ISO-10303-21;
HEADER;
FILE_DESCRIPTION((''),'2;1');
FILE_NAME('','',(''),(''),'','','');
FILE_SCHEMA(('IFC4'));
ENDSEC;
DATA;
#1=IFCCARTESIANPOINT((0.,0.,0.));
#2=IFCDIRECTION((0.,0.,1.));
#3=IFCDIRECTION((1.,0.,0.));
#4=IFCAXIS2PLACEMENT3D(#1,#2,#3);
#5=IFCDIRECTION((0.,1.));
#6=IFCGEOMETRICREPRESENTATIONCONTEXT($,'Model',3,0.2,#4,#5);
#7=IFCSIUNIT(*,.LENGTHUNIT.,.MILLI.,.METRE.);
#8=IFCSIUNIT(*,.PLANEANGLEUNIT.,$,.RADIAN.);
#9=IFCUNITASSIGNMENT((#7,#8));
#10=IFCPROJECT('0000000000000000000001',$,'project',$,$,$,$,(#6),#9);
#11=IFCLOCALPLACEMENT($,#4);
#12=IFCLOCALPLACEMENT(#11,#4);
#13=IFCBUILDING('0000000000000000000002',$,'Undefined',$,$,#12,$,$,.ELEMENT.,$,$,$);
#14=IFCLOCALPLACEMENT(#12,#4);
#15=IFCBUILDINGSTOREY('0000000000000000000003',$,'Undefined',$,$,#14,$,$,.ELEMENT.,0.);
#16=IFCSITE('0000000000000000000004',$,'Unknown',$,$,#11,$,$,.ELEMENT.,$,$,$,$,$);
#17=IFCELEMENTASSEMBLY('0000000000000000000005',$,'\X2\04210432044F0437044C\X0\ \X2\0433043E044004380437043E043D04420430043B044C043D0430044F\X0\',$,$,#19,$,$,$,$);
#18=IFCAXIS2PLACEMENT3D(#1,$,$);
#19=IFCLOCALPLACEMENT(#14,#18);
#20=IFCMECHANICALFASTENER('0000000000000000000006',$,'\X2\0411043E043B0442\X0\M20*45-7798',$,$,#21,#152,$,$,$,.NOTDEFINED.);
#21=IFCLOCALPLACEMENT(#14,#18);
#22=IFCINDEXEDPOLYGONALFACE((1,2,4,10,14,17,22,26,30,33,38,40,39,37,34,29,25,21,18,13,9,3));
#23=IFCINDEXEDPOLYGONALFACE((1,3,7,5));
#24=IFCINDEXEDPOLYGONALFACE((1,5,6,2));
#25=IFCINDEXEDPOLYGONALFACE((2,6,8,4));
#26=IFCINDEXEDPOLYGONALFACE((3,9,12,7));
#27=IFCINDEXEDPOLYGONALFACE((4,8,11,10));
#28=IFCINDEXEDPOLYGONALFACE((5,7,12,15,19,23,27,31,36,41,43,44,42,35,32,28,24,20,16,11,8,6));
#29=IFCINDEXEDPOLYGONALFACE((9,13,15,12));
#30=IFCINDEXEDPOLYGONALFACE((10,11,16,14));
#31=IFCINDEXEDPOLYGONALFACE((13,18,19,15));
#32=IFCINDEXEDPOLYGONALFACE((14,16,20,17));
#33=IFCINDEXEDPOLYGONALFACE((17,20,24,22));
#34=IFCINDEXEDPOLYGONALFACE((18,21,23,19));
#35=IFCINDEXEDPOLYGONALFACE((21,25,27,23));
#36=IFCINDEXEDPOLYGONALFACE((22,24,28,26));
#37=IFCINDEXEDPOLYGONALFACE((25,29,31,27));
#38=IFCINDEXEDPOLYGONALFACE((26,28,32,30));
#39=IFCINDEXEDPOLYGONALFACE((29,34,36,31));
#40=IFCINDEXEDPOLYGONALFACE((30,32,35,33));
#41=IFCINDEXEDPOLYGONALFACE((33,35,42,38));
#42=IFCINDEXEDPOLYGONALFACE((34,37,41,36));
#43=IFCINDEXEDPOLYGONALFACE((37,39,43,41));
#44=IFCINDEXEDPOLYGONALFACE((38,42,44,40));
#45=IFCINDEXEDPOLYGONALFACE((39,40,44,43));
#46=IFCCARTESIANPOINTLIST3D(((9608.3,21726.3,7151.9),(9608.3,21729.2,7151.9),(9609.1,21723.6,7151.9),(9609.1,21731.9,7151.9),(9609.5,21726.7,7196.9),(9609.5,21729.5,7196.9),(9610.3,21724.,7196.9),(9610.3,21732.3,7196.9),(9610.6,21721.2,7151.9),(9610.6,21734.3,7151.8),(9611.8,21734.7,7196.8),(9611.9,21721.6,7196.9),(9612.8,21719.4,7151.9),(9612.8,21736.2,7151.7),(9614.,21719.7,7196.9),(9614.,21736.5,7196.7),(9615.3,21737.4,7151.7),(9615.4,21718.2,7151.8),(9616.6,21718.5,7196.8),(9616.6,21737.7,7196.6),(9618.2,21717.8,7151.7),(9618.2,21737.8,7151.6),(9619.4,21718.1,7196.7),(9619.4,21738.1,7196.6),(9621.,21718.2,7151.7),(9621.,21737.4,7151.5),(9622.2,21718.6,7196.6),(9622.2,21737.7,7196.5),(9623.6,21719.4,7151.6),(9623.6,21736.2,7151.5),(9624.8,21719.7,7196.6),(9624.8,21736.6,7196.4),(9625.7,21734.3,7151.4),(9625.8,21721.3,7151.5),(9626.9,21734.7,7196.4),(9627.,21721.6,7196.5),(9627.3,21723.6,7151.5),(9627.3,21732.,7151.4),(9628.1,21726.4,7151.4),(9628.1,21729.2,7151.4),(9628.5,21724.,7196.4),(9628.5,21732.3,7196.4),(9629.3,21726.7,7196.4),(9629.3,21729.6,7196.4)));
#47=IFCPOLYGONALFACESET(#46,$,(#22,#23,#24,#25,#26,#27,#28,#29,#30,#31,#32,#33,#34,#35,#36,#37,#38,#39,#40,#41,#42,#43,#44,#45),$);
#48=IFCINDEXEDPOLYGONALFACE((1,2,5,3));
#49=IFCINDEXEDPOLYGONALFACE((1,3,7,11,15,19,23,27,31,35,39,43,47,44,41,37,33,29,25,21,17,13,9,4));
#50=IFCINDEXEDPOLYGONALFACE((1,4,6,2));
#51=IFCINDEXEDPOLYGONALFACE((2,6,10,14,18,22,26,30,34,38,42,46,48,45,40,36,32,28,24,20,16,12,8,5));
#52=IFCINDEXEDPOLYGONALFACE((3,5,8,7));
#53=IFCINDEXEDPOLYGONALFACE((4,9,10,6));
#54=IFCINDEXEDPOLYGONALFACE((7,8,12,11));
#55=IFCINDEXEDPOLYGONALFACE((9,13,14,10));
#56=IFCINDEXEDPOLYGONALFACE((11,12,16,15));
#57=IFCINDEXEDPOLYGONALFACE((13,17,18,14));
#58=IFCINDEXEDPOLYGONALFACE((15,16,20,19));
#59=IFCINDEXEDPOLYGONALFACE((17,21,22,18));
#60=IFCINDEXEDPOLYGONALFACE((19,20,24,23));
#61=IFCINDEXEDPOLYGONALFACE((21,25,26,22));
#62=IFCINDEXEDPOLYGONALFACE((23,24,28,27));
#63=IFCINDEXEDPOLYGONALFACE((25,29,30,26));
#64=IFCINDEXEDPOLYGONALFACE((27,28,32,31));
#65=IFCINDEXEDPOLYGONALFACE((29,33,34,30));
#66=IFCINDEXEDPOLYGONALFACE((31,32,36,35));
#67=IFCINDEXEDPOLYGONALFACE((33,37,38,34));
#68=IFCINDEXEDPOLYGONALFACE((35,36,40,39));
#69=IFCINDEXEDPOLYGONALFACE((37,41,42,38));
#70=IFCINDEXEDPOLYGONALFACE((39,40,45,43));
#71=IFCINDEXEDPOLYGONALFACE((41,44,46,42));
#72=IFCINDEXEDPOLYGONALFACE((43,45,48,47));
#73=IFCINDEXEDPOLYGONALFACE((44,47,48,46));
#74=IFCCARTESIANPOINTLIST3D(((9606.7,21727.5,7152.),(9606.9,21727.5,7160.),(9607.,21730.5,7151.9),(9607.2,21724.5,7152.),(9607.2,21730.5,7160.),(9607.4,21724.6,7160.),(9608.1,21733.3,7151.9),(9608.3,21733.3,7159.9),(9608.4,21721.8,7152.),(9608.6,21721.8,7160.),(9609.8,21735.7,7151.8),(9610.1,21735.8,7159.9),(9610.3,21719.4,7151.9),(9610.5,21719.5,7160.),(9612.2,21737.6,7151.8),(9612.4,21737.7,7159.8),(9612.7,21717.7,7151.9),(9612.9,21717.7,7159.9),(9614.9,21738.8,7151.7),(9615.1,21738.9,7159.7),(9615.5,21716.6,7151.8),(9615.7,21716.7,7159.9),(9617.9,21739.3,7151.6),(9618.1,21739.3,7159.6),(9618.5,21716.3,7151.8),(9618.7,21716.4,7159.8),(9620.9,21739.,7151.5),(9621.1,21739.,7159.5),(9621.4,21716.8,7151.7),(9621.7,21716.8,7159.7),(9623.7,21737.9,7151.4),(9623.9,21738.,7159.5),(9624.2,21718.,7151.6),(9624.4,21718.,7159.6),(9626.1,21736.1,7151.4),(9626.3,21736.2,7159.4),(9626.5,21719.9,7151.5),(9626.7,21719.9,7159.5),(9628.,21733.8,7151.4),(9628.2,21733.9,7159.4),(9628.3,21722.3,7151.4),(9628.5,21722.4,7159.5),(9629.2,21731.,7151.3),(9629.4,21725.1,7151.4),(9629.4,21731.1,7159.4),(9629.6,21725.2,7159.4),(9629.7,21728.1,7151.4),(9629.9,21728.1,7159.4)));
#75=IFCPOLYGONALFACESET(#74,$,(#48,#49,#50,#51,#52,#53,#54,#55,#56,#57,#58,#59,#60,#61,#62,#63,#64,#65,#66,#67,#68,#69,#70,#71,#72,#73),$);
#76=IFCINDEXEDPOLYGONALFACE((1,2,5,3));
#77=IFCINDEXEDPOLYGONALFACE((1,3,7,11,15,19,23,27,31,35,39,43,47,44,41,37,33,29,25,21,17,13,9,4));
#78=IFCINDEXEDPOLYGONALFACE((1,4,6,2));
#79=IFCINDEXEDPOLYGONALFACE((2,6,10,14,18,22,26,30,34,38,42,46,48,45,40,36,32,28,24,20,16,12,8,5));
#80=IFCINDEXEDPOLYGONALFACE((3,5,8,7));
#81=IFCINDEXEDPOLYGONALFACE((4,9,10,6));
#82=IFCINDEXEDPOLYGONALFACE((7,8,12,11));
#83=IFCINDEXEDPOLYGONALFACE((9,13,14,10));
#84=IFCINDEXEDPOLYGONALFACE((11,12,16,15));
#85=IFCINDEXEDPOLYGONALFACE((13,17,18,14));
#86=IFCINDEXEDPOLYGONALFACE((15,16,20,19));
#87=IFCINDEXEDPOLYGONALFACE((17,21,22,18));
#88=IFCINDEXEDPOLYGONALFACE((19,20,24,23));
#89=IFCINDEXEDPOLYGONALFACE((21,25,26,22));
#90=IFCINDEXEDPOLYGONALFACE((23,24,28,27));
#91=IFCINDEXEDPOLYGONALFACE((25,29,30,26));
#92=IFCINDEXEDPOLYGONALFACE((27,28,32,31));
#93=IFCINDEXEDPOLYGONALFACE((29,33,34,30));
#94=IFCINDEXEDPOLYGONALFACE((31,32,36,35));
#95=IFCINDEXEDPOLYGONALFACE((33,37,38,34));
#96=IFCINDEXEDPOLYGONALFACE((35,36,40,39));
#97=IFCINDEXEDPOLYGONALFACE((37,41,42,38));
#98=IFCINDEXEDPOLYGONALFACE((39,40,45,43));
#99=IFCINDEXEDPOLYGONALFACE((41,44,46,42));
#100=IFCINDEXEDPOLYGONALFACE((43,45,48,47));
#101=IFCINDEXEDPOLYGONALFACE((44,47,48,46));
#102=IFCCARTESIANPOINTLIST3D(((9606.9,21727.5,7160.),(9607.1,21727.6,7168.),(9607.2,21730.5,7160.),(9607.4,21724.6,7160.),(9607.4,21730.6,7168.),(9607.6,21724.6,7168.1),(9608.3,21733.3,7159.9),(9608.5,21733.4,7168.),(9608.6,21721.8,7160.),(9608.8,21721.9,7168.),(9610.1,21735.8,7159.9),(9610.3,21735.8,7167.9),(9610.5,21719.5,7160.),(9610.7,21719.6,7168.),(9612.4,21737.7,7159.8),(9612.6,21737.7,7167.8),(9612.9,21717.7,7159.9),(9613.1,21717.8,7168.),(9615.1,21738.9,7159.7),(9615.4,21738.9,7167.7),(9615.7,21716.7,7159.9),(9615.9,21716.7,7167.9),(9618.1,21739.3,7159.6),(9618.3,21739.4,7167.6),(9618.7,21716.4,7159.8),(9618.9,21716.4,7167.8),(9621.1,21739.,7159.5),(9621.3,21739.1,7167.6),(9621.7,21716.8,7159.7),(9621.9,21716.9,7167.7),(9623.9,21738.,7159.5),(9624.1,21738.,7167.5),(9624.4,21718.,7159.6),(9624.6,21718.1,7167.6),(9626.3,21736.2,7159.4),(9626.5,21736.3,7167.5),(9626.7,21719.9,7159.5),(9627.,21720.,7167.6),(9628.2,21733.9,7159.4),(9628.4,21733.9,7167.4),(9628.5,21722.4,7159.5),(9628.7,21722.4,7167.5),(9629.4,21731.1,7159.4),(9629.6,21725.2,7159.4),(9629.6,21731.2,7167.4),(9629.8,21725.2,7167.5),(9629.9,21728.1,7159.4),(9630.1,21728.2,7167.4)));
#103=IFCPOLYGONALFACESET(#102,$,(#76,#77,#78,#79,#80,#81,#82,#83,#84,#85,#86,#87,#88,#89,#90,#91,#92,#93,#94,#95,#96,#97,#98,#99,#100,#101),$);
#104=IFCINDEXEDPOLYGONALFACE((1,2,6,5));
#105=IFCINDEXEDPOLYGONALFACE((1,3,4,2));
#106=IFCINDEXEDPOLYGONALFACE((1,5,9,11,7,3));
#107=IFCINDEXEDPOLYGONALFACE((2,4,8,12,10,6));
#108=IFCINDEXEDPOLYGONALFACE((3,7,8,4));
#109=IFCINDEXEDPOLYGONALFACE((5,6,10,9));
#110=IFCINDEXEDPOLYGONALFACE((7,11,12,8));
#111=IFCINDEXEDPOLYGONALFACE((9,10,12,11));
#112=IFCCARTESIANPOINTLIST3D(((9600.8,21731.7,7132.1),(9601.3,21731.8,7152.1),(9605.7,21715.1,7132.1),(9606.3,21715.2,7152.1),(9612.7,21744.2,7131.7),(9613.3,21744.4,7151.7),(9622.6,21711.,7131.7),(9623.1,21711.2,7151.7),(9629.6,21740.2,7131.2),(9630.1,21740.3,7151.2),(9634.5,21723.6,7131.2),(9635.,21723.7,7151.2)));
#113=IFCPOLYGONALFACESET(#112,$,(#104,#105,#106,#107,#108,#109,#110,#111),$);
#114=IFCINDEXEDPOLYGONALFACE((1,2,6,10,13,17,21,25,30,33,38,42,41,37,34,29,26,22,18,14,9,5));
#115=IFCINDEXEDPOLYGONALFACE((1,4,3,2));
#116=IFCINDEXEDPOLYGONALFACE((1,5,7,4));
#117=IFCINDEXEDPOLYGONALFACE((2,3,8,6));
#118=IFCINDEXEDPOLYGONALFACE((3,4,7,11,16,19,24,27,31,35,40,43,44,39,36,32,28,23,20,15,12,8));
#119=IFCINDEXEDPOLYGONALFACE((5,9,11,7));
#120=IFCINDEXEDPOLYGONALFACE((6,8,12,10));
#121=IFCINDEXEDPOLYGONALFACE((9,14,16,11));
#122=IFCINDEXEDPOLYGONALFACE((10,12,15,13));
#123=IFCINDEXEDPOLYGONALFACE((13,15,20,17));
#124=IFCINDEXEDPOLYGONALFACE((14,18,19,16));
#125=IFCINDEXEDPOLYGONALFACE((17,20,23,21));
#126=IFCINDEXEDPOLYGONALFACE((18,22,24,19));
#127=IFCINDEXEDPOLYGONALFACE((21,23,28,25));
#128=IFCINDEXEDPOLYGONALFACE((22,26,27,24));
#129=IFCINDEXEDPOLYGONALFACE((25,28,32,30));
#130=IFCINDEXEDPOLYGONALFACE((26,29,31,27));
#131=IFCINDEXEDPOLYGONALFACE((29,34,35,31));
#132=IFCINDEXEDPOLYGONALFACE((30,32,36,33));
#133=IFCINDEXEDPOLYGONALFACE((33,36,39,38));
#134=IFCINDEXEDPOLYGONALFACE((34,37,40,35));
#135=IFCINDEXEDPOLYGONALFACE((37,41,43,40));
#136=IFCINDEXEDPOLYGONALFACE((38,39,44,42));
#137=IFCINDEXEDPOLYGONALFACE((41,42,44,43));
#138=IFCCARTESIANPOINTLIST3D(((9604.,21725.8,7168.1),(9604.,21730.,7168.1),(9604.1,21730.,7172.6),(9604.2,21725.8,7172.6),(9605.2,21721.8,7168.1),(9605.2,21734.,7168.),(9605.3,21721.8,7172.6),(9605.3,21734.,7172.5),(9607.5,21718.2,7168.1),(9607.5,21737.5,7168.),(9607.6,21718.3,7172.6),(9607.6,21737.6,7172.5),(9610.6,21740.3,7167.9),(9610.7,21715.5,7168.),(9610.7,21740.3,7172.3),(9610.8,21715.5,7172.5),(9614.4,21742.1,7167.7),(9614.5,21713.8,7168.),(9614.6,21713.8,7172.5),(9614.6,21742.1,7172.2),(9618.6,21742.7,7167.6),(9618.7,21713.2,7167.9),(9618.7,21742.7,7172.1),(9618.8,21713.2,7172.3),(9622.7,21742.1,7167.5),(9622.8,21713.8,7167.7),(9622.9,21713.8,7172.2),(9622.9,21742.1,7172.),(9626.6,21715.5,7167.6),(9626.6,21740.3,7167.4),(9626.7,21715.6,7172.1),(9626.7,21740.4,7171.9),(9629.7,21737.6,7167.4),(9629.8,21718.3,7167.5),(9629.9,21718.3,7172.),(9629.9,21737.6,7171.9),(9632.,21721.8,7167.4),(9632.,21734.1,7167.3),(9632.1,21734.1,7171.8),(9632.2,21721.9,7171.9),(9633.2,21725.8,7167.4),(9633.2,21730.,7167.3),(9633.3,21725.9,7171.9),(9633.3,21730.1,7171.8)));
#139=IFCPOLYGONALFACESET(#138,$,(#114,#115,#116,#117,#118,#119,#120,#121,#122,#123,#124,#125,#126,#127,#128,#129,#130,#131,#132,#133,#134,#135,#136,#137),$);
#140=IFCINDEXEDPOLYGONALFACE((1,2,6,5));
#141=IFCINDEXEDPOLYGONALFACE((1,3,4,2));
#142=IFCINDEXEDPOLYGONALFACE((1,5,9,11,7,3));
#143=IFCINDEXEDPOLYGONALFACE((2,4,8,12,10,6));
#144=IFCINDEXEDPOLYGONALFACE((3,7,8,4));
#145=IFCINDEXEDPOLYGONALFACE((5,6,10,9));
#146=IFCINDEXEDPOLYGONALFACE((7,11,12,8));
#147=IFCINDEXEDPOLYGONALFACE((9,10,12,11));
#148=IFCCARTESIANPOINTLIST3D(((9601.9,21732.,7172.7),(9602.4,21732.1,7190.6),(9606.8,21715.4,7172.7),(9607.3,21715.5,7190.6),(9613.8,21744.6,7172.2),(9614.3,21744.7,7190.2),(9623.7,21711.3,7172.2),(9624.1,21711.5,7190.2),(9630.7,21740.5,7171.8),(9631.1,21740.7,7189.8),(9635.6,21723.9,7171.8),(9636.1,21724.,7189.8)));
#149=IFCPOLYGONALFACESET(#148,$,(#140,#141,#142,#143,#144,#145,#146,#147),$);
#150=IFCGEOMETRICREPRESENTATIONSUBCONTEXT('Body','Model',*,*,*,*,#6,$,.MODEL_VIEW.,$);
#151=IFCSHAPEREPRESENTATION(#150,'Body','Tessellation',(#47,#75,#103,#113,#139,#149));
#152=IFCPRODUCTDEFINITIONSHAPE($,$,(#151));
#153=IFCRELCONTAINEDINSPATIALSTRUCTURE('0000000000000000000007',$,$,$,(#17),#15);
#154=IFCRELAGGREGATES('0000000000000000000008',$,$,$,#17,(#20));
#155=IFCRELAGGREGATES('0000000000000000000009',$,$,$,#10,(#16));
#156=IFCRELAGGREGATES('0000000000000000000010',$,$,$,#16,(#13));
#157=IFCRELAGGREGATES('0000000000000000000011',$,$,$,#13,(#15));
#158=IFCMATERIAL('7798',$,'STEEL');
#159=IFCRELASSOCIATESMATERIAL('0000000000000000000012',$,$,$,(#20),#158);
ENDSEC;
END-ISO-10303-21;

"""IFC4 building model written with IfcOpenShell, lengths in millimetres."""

from ifc_helpers import new_model, si_unit, direction, frame, origin_with_axes, place, context, subcontext, project, spatial, line, arc, indexed_curve, outline, extrude, source, transform, mapped, material, element, aggregate, save


model = new_model("IFC4")

# Units and contexts
model_context = context("Model", 3, precision=0.2, world=origin_with_axes(), true_north=direction((0.0, 1.0)))
body_context = subcontext(model_context, "Body", "Model", "MODEL_VIEW")
ifc_project = project(units=[si_unit("LENGTHUNIT", "METRE", prefix="MILLI"), si_unit("PLANEANGLEUNIT", "RADIAN")], contexts=[model_context])

# Site, building, storey
site_placement = place(None, origin_with_axes())
site = spatial("IfcSite", under=ifc_project, at=site_placement, Name="Unknown", CompositionType="ELEMENT")
building_placement = place(site_placement, origin_with_axes())
building = spatial("IfcBuilding", under=site, at=building_placement, Name="Undefined", CompositionType="ELEMENT")
storey_placement = place(building_placement, origin_with_axes())
storey = spatial("IfcBuildingStorey", under=building, at=storey_placement, Name="Undefined", CompositionType="ELEMENT", Elevation=0.0)

# Element assembly
assembly_1_placement = place(storey_placement, frame((8658.2, 21443.5, 7192.2), z_axis=(0.285231, -0.953702, 0.09537), x_axis=(0.958459, 0.283816, -0.028382)))
assembly_1 = element("IfcElementAssembly", 1, at=assembly_1_placement, inside=storey, Name="Связь горизонтальная")

# Shared definitions
ifc_material_1 = material(Name="7798", Category="STEEL")

# Mechanical fastener
shared_shape_1 = source(origin_with_axes(), body_context, "Body", "SweptSolid", [
    extrude(outline(indexed_curve([(10.0, 0.0), (0.0, 10.0), (-10.0, 0.0), (0.0, -10.0)], segments=[arc(1, 2, 3), arc(3, 4, 1)])), frame((0.0, 0.0, 12.1), z_axis=(0.0, 0.0, -1.0), x_axis=(0.0, 1.0, 0.0)), (0.0, 0.0, 1.0), 45.0),
    extrude(outline(indexed_curve([(0.0, 11.5), (8.1, 8.1), (11.5, 0.0), (8.1, -8.1), (0.0, -11.5), (-1.0, -11.5), (-11.5, 0.0), (-8.1, 8.1)], segments=[arc(1, 2, 3), arc(3, 4, 5), arc(5, 6, 7), arc(7, 8, 1)])), frame((0.0, 0.0, 12.1), z_axis=(0.0, 0.0, -1.0), x_axis=(0.0, 1.0, 0.0)), (0.0, 0.0, 1.0), 8.0),
    extrude(outline(indexed_curve([(0.0, 11.5), (8.1, 8.1), (11.5, 0.0), (8.1, -8.1), (0.0, -11.5), (-1.0, -11.5), (-11.5, 0.0), (-8.1, 8.1)], segments=[arc(1, 2, 3), arc(3, 4, 5), arc(5, 6, 7), arc(7, 8, 1)])), frame((0.0, 0.0, 4.0), z_axis=(0.0, 0.0, -1.0), x_axis=(0.0, 1.0, 0.0)), (0.0, 0.0, 1.0), 8.0),
    extrude(outline(indexed_curve([(17.3, 0.0), (8.7, 15.0), (-8.7, 15.0), (-17.3, 0.0), (-8.7, -15.0), (8.7, -15.0)], segments=[line(1, 2, 3, 4, 5, 6, 1)])), frame((0.0, 0.0, 32.1), z_axis=(0.0, 0.0, -1.0), x_axis=(0.0, 1.0, 0.0)), (0.0, 0.0, 1.0), 20.0),
    extrude(outline(indexed_curve([(14.8, 0.0), (0.0, 14.8), (-14.8, 0.0), (0.0, -14.8)], segments=[arc(1, 2, 3), arc(3, 4, 1)])), frame((0.0, 0.0, -4.0), z_axis=(0.0, 0.0, -1.0), x_axis=(0.0, 1.0, 0.0)), (0.0, 0.0, 1.0), 4.5),
    extrude(outline(indexed_curve([(17.3, 0.0), (8.7, 15.0), (-8.7, 15.0), (-17.3, 0.0), (-8.7, -15.0), (8.7, -15.0)], segments=[line(1, 2, 3, 4, 5, 6, 1)])), frame((0.0, 0.0, -8.5), z_axis=(0.0, 0.0, -1.0), x_axis=(0.0, 1.0, 0.0)), (0.0, 0.0, 1.0), 18.0),
])
mechanical_fastener_1_placement = place(assembly_1_placement, frame((1002.0, 0.0, 0.0), z_axis=(0.0, -0.995438, -0.095409), x_axis=(-1.0, 0.0, 0.0)))
mechanical_fastener_1 = element("IfcMechanicalFastener", 2, at=mechanical_fastener_1_placement, material=ifc_material_1, Name="БолтM20*45-7798", PredefinedType="NOTDEFINED", context=body_context, shape_type="MappedRepresentation", body=[
    mapped(shared_shape_1, transform((0.0, 0.0, 0.0))),
])
aggregate(assembly_1, [mechanical_fastener_1])

save(model, "model.ifc")
